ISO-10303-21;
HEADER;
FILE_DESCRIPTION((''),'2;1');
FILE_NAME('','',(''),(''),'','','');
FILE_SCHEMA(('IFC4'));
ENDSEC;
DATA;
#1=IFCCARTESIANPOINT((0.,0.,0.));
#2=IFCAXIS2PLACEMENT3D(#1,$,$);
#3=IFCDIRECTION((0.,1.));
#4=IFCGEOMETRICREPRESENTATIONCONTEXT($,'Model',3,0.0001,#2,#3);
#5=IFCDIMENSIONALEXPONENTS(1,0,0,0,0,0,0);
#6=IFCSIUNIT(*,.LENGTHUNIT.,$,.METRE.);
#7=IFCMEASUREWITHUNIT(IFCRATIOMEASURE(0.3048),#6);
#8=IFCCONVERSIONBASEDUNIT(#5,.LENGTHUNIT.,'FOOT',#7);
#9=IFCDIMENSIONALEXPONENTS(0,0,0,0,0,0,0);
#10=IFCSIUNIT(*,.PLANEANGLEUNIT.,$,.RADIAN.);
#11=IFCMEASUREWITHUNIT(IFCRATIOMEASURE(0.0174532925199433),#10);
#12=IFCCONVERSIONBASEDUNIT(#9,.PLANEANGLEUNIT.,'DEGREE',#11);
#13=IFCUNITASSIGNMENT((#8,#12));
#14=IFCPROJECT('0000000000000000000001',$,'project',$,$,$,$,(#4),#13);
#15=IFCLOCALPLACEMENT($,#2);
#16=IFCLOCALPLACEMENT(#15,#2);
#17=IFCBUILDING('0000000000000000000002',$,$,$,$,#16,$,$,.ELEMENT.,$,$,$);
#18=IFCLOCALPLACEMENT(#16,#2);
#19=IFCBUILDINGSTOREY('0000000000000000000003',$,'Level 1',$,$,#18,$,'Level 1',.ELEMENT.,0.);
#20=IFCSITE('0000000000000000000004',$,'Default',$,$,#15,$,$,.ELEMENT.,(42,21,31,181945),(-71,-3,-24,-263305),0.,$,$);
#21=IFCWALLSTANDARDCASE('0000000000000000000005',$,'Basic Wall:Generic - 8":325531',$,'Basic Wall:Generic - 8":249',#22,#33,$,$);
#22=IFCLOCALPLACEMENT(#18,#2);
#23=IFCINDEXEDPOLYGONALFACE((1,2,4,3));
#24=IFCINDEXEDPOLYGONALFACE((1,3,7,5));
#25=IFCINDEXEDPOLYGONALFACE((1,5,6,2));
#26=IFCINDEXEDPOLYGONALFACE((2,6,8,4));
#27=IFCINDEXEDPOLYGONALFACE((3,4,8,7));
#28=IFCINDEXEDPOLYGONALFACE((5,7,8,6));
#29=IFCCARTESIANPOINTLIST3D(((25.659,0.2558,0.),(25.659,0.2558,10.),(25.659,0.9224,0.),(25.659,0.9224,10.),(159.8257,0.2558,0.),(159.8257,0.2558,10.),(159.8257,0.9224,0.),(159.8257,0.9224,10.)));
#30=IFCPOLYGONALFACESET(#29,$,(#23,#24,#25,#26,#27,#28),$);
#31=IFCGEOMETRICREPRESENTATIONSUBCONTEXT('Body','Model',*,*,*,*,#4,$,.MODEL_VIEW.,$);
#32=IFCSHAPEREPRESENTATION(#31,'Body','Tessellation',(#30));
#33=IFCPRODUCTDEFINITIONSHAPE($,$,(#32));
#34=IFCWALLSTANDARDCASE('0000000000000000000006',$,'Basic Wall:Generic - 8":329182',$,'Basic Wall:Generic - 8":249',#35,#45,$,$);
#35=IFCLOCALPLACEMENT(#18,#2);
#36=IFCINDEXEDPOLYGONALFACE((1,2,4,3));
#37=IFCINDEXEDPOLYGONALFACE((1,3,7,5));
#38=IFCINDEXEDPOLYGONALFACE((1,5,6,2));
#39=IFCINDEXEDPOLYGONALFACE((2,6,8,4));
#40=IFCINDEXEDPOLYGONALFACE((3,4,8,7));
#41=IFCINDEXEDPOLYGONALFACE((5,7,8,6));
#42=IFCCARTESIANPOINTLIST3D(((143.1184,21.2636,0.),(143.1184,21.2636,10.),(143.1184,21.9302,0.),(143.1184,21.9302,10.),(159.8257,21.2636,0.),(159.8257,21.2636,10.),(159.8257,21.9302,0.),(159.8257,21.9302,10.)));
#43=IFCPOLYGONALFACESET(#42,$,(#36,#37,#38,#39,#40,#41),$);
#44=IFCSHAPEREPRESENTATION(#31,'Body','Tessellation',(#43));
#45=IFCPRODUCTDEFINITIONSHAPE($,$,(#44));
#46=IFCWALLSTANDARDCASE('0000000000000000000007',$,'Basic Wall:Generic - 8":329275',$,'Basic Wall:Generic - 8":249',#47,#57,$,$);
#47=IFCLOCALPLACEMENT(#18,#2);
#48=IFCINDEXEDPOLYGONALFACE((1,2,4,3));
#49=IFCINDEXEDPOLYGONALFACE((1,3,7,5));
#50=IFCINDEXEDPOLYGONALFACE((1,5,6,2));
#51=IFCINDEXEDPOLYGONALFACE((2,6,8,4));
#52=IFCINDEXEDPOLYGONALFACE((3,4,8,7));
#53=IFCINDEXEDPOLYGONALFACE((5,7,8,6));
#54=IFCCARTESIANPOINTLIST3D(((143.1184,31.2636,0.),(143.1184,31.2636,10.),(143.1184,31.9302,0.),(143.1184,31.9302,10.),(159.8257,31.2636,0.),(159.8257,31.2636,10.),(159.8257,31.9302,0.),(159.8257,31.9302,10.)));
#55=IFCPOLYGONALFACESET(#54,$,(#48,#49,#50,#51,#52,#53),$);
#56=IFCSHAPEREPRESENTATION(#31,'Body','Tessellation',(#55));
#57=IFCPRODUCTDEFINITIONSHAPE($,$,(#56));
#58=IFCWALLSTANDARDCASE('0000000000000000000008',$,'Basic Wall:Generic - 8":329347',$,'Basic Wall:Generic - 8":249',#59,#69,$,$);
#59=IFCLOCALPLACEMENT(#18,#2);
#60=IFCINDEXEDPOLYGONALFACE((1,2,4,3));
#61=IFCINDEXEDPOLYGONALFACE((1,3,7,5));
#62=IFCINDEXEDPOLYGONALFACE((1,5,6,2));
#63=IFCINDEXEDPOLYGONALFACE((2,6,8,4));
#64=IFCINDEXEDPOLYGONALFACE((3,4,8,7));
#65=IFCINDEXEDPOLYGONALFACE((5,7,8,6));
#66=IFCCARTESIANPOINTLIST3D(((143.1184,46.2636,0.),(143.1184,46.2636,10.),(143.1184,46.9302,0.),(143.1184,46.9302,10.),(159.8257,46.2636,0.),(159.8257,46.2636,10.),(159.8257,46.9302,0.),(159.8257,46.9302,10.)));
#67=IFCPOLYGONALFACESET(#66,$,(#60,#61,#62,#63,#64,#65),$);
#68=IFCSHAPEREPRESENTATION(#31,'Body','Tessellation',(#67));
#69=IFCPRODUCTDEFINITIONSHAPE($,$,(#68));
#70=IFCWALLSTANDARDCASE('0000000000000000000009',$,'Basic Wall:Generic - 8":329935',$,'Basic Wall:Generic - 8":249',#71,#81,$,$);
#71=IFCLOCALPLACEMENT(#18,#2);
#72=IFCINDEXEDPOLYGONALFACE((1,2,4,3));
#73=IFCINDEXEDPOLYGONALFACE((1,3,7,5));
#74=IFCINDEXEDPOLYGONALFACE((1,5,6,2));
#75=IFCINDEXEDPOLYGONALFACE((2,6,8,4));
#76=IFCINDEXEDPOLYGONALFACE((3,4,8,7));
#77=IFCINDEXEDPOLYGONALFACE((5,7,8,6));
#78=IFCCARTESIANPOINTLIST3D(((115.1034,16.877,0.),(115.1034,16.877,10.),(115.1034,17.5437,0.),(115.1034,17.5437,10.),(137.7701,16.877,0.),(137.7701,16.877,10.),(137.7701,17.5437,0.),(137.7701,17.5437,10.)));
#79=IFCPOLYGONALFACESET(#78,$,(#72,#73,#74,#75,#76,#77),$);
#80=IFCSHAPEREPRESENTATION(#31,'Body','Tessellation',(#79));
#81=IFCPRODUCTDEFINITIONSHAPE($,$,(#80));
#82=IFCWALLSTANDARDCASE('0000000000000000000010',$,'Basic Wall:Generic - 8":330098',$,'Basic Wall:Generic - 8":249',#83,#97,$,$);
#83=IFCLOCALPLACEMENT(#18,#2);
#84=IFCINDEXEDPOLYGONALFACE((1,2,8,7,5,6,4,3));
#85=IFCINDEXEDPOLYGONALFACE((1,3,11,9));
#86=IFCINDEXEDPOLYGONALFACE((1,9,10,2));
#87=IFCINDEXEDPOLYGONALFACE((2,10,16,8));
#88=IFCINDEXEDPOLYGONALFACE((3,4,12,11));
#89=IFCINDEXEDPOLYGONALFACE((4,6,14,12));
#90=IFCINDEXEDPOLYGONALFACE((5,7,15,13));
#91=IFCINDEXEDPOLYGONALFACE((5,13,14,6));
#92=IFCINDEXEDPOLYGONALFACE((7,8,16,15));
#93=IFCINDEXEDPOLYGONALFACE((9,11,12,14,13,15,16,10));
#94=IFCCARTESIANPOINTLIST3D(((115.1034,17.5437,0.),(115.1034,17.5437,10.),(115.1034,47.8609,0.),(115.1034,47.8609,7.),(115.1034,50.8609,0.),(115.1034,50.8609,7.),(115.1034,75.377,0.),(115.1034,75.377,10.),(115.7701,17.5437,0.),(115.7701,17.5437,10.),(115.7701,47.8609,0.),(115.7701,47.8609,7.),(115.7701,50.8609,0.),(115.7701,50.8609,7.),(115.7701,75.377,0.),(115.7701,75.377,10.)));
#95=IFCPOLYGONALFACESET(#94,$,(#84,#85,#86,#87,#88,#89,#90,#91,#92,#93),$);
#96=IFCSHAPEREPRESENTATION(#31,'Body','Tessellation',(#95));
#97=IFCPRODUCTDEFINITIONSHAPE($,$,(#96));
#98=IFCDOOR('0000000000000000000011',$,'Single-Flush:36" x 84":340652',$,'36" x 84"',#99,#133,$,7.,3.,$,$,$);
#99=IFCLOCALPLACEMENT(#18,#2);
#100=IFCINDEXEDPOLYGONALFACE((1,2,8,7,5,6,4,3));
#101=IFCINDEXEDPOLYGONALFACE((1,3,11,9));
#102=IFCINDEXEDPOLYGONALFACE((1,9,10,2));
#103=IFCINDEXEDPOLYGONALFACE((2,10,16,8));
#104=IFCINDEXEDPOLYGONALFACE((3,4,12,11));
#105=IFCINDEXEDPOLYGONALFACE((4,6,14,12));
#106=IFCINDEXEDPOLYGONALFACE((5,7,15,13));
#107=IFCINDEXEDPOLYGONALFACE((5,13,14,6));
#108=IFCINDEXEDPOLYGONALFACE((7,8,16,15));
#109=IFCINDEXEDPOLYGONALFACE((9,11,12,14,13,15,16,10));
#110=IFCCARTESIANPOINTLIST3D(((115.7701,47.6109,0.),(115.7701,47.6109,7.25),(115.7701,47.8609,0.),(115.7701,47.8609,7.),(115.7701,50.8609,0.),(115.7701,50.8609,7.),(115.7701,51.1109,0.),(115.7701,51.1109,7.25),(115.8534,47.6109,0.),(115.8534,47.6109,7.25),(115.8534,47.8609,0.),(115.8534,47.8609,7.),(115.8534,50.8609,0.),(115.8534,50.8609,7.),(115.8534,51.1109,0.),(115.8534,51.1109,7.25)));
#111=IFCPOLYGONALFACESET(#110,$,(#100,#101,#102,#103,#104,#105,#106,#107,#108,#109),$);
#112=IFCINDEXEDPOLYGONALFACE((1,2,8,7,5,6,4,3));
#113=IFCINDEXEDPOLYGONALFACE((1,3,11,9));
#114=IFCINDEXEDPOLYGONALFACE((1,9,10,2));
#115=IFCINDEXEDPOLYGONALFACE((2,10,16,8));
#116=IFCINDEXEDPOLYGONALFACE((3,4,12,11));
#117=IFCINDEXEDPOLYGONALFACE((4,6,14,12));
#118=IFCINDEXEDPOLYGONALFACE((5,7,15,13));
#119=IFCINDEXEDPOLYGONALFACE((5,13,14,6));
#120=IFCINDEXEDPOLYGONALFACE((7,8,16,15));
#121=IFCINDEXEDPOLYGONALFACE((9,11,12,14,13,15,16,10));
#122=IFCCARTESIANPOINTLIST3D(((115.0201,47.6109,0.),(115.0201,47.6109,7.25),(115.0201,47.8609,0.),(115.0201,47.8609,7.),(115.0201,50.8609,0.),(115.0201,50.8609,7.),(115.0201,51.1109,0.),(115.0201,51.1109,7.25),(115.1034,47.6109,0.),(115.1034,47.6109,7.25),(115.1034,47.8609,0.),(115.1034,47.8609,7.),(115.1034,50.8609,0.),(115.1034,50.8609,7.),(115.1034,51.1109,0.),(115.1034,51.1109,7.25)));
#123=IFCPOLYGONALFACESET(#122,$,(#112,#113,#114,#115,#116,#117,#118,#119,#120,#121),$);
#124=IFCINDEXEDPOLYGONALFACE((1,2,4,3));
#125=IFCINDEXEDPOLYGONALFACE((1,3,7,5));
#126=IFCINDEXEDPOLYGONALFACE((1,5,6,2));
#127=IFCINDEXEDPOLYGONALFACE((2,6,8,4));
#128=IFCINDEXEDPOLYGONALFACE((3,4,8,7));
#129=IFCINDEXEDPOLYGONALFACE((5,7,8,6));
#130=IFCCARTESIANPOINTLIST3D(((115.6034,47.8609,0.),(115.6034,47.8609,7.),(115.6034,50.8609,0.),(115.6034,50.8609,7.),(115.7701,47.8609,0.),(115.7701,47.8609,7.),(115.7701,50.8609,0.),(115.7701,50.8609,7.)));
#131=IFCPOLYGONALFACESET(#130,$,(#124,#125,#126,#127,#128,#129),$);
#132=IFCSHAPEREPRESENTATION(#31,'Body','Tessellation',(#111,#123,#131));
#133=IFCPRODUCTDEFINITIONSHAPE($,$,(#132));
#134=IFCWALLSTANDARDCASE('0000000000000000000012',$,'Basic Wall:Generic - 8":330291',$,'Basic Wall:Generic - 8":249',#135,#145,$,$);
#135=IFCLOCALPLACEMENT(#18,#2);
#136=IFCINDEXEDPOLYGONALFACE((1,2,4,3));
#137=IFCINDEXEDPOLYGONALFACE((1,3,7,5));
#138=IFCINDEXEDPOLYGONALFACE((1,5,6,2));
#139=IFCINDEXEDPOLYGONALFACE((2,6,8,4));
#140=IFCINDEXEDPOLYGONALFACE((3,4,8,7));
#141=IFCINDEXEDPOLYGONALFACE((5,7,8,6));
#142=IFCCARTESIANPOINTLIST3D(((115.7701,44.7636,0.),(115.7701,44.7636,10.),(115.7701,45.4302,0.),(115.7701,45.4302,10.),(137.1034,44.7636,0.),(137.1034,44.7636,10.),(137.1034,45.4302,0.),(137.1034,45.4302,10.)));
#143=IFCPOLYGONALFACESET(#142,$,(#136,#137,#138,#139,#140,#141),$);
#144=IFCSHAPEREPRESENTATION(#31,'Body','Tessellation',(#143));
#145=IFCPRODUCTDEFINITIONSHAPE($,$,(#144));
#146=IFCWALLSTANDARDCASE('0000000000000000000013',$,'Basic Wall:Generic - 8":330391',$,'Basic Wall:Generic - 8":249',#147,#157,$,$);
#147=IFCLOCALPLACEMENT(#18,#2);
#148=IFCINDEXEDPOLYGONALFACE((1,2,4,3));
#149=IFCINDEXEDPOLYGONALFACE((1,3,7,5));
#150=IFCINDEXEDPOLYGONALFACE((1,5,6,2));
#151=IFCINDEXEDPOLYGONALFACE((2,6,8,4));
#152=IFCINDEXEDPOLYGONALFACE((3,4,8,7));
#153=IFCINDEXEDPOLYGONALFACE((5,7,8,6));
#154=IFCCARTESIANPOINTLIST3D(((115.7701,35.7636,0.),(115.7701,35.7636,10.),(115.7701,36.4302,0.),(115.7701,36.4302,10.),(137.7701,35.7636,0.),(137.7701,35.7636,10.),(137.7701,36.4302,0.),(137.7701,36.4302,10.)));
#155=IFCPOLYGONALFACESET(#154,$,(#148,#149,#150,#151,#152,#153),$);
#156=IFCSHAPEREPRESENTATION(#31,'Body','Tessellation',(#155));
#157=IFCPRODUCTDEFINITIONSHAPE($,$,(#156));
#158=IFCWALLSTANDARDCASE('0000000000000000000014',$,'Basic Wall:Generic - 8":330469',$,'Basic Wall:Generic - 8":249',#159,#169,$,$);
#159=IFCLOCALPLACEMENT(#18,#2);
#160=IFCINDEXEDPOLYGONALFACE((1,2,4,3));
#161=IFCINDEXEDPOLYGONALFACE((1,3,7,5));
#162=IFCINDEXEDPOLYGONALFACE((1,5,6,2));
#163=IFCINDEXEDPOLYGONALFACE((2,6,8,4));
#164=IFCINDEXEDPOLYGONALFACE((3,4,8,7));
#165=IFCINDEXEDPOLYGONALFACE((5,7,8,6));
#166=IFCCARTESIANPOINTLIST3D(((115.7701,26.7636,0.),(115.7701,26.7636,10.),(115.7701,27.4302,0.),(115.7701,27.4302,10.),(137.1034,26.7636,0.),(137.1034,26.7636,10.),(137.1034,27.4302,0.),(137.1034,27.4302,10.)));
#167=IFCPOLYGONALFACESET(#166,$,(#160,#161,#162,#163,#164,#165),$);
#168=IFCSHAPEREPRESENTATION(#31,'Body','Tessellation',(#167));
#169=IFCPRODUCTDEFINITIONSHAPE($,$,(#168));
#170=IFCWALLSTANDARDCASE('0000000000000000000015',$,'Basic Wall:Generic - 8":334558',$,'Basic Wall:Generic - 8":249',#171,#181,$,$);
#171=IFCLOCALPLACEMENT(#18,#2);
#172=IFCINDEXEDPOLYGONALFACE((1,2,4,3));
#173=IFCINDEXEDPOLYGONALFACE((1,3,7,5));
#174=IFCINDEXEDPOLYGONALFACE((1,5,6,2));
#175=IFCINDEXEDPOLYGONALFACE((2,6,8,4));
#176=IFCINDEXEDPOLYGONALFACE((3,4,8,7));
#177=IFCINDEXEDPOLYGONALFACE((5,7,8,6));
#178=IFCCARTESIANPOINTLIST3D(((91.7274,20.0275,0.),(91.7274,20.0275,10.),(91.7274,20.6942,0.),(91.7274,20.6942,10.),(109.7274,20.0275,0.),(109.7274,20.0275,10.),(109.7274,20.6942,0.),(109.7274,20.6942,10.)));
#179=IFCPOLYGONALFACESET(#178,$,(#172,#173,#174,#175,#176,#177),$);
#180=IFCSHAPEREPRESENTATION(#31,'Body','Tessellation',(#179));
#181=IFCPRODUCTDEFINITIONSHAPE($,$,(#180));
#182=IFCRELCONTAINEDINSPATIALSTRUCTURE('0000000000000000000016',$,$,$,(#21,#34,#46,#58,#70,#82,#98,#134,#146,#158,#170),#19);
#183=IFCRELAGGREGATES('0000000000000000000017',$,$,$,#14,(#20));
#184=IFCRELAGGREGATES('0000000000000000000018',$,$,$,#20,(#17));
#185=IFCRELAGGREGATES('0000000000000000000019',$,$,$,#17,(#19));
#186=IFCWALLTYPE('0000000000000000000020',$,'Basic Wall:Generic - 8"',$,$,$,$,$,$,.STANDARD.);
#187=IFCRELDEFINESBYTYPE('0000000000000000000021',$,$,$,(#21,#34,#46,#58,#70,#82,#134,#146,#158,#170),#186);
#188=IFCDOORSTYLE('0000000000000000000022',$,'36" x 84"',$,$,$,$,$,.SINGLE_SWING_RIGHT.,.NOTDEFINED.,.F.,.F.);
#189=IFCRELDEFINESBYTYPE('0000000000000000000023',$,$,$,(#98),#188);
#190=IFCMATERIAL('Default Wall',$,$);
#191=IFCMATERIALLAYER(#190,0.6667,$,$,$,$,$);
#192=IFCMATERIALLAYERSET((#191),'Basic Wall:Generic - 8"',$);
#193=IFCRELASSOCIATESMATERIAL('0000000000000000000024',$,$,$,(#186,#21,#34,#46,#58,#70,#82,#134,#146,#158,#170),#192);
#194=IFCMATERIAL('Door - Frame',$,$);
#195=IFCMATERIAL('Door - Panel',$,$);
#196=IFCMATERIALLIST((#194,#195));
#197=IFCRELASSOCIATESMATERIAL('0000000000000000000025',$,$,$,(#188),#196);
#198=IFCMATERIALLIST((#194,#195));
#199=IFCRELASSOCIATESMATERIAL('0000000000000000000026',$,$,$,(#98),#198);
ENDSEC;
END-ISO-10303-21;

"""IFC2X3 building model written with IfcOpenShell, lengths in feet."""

from ifc_helpers import new_model, entity, si_unit, converted_unit, direction, frame, frame_2d, origin, place, context, subcontext, project, spatial, polyline, rectangle, outline, extrude, source, transform, mapped, material, material_list, layer, layer_set, layer_usage, type_object, type_shapes, element, fill, save


model = new_model("IFC2X3")

# Units and contexts
model_context = context("Model", 3, precision=0.0001, world=origin(), true_north=direction((0.0, 1.0)))
body_context = subcontext(model_context, "Body", "Model", "MODEL_VIEW")
ifc_project = project(units=[converted_unit("LENGTHUNIT", "FOOT", entity("IfcRatioMeasure", 0.3048), si_unit("LENGTHUNIT", "METRE"), dimensions=[1, 0, 0, 0, 0, 0, 0]), converted_unit("PLANEANGLEUNIT", "DEGREE", entity("IfcRatioMeasure", 0.0174532925199433), si_unit("PLANEANGLEUNIT", "RADIAN"), dimensions=[0, 0, 0, 0, 0, 0, 0])], contexts=[model_context])

# Site, building, storey
site_placement = place(None, origin())
site = spatial("IfcSite", under=ifc_project, at=site_placement, Name="Default", CompositionType="ELEMENT", RefLatitude=(42, 21, 31, 181945), RefLongitude=(-71, -3, -24, -263305), RefElevation=0.0)
building_placement = place(site_placement, origin())
building = spatial("IfcBuilding", under=site, at=building_placement, CompositionType="ELEMENT")
storey_placement = place(building_placement, origin())
storey = spatial("IfcBuildingStorey", under=building, at=storey_placement, Name="Level 1", LongName="Level 1", CompositionType="ELEMENT", Elevation=0.0)

# Walls
ifc_material_1 = material(Name="Default Wall")
ifc_layer = layer(ifc_material_1, 0.6667)
ifc_layer_set = layer_set([ifc_layer], Name="Basic Wall:Generic - 8\"")
ifc_layer_usage_1 = layer_usage(ifc_layer_set, "AXIS2", "NEGATIVE", 0.3333)
wall_type = type_object("IfcWallType", Name="Basic Wall:Generic - 8\"", PredefinedType="STANDARD", material=ifc_layer_set)
wall_1_placement = place(storey_placement, frame((159.8257, 0.5891, 0.0), z_axis=(0.0, 0.0, 1.0), x_axis=(-1.0, 0.0, 0.0)))
element("IfcWallStandardCase", 1, at=wall_1_placement, inside=storey, type_object=wall_type, material=ifc_layer_usage_1, Name="Basic Wall:Generic - 8\":325531", ObjectType="Basic Wall:Generic - 8\":249", context=body_context, shape_type="SweptSolid", body=[
    extrude(rectangle(XDim=134.1667, YDim=0.6667, at=frame_2d((67.0833, 0.0), x_axis=(-1.0, 0.0))), origin(), (0.0, 0.0, 1.0), 10.0),
])
ifc_layer_usage_2 = layer_usage(ifc_layer_set, "AXIS2", "NEGATIVE", 0.3333)
wall_2_placement = place(storey_placement, frame((143.1184, 21.5969, 0.0)))
element("IfcWallStandardCase", 2, at=wall_2_placement, inside=storey, type_object=wall_type, material=ifc_layer_usage_2, Name="Basic Wall:Generic - 8\":329182", ObjectType="Basic Wall:Generic - 8\":249", context=body_context, shape_type="SweptSolid", body=[
    extrude(rectangle(XDim=16.7072, YDim=0.6667, at=frame_2d((8.3536, 0.0), x_axis=(-1.0, 0.0))), origin(), (0.0, 0.0, 1.0), 10.0),
])
ifc_layer_usage_3 = layer_usage(ifc_layer_set, "AXIS2", "NEGATIVE", 0.3333)
wall_3_placement = place(storey_placement, frame((159.8257, 31.5969, 0.0), z_axis=(0.0, 0.0, 1.0), x_axis=(-1.0, 0.0, 0.0)))
element("IfcWallStandardCase", 3, at=wall_3_placement, inside=storey, type_object=wall_type, material=ifc_layer_usage_3, Name="Basic Wall:Generic - 8\":329275", ObjectType="Basic Wall:Generic - 8\":249", context=body_context, shape_type="SweptSolid", body=[
    extrude(rectangle(XDim=16.7072, YDim=0.6667, at=frame_2d((8.3536, 0.0), x_axis=(-1.0, 0.0))), origin(), (0.0, 0.0, 1.0), 10.0),
])
ifc_layer_usage_4 = layer_usage(ifc_layer_set, "AXIS2", "NEGATIVE", 0.3333)
wall_4_placement = place(storey_placement, frame((159.8257, 46.5969, 0.0), z_axis=(0.0, 0.0, 1.0), x_axis=(-1.0, 0.0, 0.0)))
element("IfcWallStandardCase", 4, at=wall_4_placement, inside=storey, type_object=wall_type, material=ifc_layer_usage_4, Name="Basic Wall:Generic - 8\":329347", ObjectType="Basic Wall:Generic - 8\":249", context=body_context, shape_type="SweptSolid", body=[
    extrude(rectangle(XDim=16.7072, YDim=0.6667, at=frame_2d((8.3536, 0.0), x_axis=(-1.0, 0.0))), origin(), (0.0, 0.0, 1.0), 10.0),
])
ifc_layer_usage_5 = layer_usage(ifc_layer_set, "AXIS2", "NEGATIVE", 0.3333)
wall_5_placement = place(storey_placement, frame((137.7701, 17.2104, 0.0), z_axis=(0.0, 0.0, 1.0), x_axis=(-1.0, 0.0, 0.0)))
element("IfcWallStandardCase", 5, at=wall_5_placement, inside=storey, type_object=wall_type, material=ifc_layer_usage_5, Name="Basic Wall:Generic - 8\":329935", ObjectType="Basic Wall:Generic - 8\":249", context=body_context, shape_type="SweptSolid", body=[
    extrude(rectangle(XDim=22.6667, YDim=0.6667, at=frame_2d((11.3333, 0.0), x_axis=(-1.0, 0.0))), origin(), (0.0, 0.0, 1.0), 10.0),
])

# Wall, opening, door
ifc_layer_usage_6 = layer_usage(ifc_layer_set, "AXIS2", "NEGATIVE", 0.3333)
wall_6_placement = place(storey_placement, frame((115.4368, 17.5437, 0.0), z_axis=(0.0, 0.0, 1.0), x_axis=(0.0, 1.0, 0.0)))
wall_6 = element("IfcWallStandardCase", 6, at=wall_6_placement, inside=storey, type_object=wall_type, material=ifc_layer_usage_6, Name="Basic Wall:Generic - 8\":330098", ObjectType="Basic Wall:Generic - 8\":249", context=body_context, shape_type="SweptSolid", body=[
    extrude(rectangle(XDim=57.8333, YDim=0.6667, at=frame_2d((28.9167, 0.0), x_axis=(-1.0, 0.0))), origin(), (0.0, 0.0, 1.0), 10.0),
])
opening_1_placement = place(wall_6_placement, frame((33.3172, 0.3333, 0.0)))
opening_1 = element("IfcOpeningElement", 7, at=opening_1_placement, cuts=wall_6, ObjectType="Opening", context=body_context, shape_type="SweptSolid", body=[
    extrude(rectangle(XDim=3.0, YDim=7.0, at=frame_2d((3.5, 1.5), x_axis=(0.0, 1.0))), frame((0.0, 0.0, 0.0), z_axis=(0.0, -1.0, 0.0), x_axis=(0.0, 0.0, 1.0)), (0.0, 0.0, 1.0), 0.6667),
])
ifc_material_2 = material(Name="Door - Frame")
ifc_material_3 = material(Name="Door - Panel")
ifc_material_list_1 = material_list([ifc_material_2, ifc_material_3])
ifc_material_list_2 = material_list([ifc_material_2, ifc_material_3])
door_style = type_object("IfcDoorStyle", Name="36\" x 84\"", ConstructionType="NOTDEFINED", OperationType="SINGLE_SWING_RIGHT", ParameterTakesPrecedence=False, Sizeable=False, material=ifc_material_list_2)
shared_shape = source(origin(), body_context, "Body", "SweptSolid", [
    extrude(outline(polyline([(-1.75, -3.6875), (1.75, -3.6875), (1.75, 3.5625), (1.5, 3.5625), (1.5, -3.4375), (-1.5, -3.4375), (-1.5, 3.5625), (-1.75, 3.5625), (-1.75, -3.6875)])), frame((1.5, 0.6667, 3.5625), z_axis=(0.0, 1.0, 0.0), x_axis=(1.0, 0.0, 0.0)), (0.0, 0.0, 1.0), 0.0833),
    extrude(outline(polyline([(-3.6875, -1.75), (3.5625, -1.75), (3.5625, -1.5), (-3.4375, -1.5), (-3.4375, 1.5), (3.5625, 1.5), (3.5625, 1.75), (-3.6875, 1.75), (-3.6875, -1.75)])), frame((1.5, -0.0833, 3.5625), z_axis=(0.0, 1.0, 0.0), x_axis=(0.0, 0.0, -1.0)), (0.0, 0.0, 1.0), 0.0833),
    extrude(rectangle(XDim=0.1667, YDim=3.0, at=frame_2d((0.0, 0.0), x_axis=(1.0, 0.0))), frame((1.5, 0.5833, 0.0), z_axis=(0.0, 0.0, 1.0), x_axis=(0.0, 1.0, 0.0)), (0.0, 0.0, 1.0), 7.0),
])
type_shapes(door_style, [shared_shape])
door_1_placement = place(opening_1_placement, frame((0.0, 0.0, 0.0), z_axis=(0.0, 0.0, 1.0), x_axis=(-1.0, 0.0, 0.0)))
door_1 = element("IfcDoor", 8, at=door_1_placement, inside=storey, type_object=door_style, material=ifc_material_list_1, Name="Single-Flush:36\" x 84\":340652", ObjectType="36\" x 84\"", OverallHeight=7.0, OverallWidth=3.0, context=body_context, shape_type="MappedRepresentation", body=[
    mapped(shared_shape, transform((0.0, 0.0, 0.0), scale=1.0)),
])
fill(opening_1, door_1)

# Walls
ifc_layer_usage_7 = layer_usage(ifc_layer_set, "AXIS2", "NEGATIVE", 0.3333)
wall_7_placement = place(storey_placement, frame((137.1034, 45.0969, 0.0), z_axis=(0.0, 0.0, 1.0), x_axis=(-1.0, 0.0, 0.0)))
element("IfcWallStandardCase", 9, at=wall_7_placement, inside=storey, type_object=wall_type, material=ifc_layer_usage_7, Name="Basic Wall:Generic - 8\":330291", ObjectType="Basic Wall:Generic - 8\":249", context=body_context, shape_type="SweptSolid", body=[
    extrude(rectangle(XDim=21.3333, YDim=0.6667, at=frame_2d((10.6667, 0.0), x_axis=(-1.0, 0.0))), origin(), (0.0, 0.0, 1.0), 10.0),
])
ifc_layer_usage_8 = layer_usage(ifc_layer_set, "AXIS2", "NEGATIVE", 0.3333)
wall_8_placement = place(storey_placement, frame((115.7701, 36.0969, 0.0)))
element("IfcWallStandardCase", 10, at=wall_8_placement, inside=storey, type_object=wall_type, material=ifc_layer_usage_8, Name="Basic Wall:Generic - 8\":330391", ObjectType="Basic Wall:Generic - 8\":249", context=body_context, shape_type="SweptSolid", body=[
    extrude(rectangle(XDim=22.0, YDim=0.6667, at=frame_2d((11.0, 0.0), x_axis=(-1.0, 0.0))), origin(), (0.0, 0.0, 1.0), 10.0),
])
ifc_layer_usage_9 = layer_usage(ifc_layer_set, "AXIS2", "NEGATIVE", 0.3333)
wall_9_placement = place(storey_placement, frame((137.1034, 27.0969, 0.0), z_axis=(0.0, 0.0, 1.0), x_axis=(-1.0, 0.0, 0.0)))
element("IfcWallStandardCase", 11, at=wall_9_placement, inside=storey, type_object=wall_type, material=ifc_layer_usage_9, Name="Basic Wall:Generic - 8\":330469", ObjectType="Basic Wall:Generic - 8\":249", context=body_context, shape_type="SweptSolid", body=[
    extrude(rectangle(XDim=21.3333, YDim=0.6667, at=frame_2d((10.6667, 0.0), x_axis=(-1.0, 0.0))), origin(), (0.0, 0.0, 1.0), 10.0),
])
ifc_layer_usage_10 = layer_usage(ifc_layer_set, "AXIS2", "NEGATIVE", 0.3333)
wall_10_placement = place(storey_placement, frame((109.7274, 20.3609, 0.0), z_axis=(0.0, 0.0, 1.0), x_axis=(-1.0, 0.0, 0.0)))
element("IfcWallStandardCase", 12, at=wall_10_placement, inside=storey, type_object=wall_type, material=ifc_layer_usage_10, Name="Basic Wall:Generic - 8\":334558", ObjectType="Basic Wall:Generic - 8\":249", context=body_context, shape_type="SweptSolid", body=[
    extrude(rectangle(XDim=18.0, YDim=0.6667, at=frame_2d((9.0, 0.0), x_axis=(-1.0, 0.0))), origin(), (0.0, 0.0, 1.0), 10.0),
])

save(model, "model.ifc")
